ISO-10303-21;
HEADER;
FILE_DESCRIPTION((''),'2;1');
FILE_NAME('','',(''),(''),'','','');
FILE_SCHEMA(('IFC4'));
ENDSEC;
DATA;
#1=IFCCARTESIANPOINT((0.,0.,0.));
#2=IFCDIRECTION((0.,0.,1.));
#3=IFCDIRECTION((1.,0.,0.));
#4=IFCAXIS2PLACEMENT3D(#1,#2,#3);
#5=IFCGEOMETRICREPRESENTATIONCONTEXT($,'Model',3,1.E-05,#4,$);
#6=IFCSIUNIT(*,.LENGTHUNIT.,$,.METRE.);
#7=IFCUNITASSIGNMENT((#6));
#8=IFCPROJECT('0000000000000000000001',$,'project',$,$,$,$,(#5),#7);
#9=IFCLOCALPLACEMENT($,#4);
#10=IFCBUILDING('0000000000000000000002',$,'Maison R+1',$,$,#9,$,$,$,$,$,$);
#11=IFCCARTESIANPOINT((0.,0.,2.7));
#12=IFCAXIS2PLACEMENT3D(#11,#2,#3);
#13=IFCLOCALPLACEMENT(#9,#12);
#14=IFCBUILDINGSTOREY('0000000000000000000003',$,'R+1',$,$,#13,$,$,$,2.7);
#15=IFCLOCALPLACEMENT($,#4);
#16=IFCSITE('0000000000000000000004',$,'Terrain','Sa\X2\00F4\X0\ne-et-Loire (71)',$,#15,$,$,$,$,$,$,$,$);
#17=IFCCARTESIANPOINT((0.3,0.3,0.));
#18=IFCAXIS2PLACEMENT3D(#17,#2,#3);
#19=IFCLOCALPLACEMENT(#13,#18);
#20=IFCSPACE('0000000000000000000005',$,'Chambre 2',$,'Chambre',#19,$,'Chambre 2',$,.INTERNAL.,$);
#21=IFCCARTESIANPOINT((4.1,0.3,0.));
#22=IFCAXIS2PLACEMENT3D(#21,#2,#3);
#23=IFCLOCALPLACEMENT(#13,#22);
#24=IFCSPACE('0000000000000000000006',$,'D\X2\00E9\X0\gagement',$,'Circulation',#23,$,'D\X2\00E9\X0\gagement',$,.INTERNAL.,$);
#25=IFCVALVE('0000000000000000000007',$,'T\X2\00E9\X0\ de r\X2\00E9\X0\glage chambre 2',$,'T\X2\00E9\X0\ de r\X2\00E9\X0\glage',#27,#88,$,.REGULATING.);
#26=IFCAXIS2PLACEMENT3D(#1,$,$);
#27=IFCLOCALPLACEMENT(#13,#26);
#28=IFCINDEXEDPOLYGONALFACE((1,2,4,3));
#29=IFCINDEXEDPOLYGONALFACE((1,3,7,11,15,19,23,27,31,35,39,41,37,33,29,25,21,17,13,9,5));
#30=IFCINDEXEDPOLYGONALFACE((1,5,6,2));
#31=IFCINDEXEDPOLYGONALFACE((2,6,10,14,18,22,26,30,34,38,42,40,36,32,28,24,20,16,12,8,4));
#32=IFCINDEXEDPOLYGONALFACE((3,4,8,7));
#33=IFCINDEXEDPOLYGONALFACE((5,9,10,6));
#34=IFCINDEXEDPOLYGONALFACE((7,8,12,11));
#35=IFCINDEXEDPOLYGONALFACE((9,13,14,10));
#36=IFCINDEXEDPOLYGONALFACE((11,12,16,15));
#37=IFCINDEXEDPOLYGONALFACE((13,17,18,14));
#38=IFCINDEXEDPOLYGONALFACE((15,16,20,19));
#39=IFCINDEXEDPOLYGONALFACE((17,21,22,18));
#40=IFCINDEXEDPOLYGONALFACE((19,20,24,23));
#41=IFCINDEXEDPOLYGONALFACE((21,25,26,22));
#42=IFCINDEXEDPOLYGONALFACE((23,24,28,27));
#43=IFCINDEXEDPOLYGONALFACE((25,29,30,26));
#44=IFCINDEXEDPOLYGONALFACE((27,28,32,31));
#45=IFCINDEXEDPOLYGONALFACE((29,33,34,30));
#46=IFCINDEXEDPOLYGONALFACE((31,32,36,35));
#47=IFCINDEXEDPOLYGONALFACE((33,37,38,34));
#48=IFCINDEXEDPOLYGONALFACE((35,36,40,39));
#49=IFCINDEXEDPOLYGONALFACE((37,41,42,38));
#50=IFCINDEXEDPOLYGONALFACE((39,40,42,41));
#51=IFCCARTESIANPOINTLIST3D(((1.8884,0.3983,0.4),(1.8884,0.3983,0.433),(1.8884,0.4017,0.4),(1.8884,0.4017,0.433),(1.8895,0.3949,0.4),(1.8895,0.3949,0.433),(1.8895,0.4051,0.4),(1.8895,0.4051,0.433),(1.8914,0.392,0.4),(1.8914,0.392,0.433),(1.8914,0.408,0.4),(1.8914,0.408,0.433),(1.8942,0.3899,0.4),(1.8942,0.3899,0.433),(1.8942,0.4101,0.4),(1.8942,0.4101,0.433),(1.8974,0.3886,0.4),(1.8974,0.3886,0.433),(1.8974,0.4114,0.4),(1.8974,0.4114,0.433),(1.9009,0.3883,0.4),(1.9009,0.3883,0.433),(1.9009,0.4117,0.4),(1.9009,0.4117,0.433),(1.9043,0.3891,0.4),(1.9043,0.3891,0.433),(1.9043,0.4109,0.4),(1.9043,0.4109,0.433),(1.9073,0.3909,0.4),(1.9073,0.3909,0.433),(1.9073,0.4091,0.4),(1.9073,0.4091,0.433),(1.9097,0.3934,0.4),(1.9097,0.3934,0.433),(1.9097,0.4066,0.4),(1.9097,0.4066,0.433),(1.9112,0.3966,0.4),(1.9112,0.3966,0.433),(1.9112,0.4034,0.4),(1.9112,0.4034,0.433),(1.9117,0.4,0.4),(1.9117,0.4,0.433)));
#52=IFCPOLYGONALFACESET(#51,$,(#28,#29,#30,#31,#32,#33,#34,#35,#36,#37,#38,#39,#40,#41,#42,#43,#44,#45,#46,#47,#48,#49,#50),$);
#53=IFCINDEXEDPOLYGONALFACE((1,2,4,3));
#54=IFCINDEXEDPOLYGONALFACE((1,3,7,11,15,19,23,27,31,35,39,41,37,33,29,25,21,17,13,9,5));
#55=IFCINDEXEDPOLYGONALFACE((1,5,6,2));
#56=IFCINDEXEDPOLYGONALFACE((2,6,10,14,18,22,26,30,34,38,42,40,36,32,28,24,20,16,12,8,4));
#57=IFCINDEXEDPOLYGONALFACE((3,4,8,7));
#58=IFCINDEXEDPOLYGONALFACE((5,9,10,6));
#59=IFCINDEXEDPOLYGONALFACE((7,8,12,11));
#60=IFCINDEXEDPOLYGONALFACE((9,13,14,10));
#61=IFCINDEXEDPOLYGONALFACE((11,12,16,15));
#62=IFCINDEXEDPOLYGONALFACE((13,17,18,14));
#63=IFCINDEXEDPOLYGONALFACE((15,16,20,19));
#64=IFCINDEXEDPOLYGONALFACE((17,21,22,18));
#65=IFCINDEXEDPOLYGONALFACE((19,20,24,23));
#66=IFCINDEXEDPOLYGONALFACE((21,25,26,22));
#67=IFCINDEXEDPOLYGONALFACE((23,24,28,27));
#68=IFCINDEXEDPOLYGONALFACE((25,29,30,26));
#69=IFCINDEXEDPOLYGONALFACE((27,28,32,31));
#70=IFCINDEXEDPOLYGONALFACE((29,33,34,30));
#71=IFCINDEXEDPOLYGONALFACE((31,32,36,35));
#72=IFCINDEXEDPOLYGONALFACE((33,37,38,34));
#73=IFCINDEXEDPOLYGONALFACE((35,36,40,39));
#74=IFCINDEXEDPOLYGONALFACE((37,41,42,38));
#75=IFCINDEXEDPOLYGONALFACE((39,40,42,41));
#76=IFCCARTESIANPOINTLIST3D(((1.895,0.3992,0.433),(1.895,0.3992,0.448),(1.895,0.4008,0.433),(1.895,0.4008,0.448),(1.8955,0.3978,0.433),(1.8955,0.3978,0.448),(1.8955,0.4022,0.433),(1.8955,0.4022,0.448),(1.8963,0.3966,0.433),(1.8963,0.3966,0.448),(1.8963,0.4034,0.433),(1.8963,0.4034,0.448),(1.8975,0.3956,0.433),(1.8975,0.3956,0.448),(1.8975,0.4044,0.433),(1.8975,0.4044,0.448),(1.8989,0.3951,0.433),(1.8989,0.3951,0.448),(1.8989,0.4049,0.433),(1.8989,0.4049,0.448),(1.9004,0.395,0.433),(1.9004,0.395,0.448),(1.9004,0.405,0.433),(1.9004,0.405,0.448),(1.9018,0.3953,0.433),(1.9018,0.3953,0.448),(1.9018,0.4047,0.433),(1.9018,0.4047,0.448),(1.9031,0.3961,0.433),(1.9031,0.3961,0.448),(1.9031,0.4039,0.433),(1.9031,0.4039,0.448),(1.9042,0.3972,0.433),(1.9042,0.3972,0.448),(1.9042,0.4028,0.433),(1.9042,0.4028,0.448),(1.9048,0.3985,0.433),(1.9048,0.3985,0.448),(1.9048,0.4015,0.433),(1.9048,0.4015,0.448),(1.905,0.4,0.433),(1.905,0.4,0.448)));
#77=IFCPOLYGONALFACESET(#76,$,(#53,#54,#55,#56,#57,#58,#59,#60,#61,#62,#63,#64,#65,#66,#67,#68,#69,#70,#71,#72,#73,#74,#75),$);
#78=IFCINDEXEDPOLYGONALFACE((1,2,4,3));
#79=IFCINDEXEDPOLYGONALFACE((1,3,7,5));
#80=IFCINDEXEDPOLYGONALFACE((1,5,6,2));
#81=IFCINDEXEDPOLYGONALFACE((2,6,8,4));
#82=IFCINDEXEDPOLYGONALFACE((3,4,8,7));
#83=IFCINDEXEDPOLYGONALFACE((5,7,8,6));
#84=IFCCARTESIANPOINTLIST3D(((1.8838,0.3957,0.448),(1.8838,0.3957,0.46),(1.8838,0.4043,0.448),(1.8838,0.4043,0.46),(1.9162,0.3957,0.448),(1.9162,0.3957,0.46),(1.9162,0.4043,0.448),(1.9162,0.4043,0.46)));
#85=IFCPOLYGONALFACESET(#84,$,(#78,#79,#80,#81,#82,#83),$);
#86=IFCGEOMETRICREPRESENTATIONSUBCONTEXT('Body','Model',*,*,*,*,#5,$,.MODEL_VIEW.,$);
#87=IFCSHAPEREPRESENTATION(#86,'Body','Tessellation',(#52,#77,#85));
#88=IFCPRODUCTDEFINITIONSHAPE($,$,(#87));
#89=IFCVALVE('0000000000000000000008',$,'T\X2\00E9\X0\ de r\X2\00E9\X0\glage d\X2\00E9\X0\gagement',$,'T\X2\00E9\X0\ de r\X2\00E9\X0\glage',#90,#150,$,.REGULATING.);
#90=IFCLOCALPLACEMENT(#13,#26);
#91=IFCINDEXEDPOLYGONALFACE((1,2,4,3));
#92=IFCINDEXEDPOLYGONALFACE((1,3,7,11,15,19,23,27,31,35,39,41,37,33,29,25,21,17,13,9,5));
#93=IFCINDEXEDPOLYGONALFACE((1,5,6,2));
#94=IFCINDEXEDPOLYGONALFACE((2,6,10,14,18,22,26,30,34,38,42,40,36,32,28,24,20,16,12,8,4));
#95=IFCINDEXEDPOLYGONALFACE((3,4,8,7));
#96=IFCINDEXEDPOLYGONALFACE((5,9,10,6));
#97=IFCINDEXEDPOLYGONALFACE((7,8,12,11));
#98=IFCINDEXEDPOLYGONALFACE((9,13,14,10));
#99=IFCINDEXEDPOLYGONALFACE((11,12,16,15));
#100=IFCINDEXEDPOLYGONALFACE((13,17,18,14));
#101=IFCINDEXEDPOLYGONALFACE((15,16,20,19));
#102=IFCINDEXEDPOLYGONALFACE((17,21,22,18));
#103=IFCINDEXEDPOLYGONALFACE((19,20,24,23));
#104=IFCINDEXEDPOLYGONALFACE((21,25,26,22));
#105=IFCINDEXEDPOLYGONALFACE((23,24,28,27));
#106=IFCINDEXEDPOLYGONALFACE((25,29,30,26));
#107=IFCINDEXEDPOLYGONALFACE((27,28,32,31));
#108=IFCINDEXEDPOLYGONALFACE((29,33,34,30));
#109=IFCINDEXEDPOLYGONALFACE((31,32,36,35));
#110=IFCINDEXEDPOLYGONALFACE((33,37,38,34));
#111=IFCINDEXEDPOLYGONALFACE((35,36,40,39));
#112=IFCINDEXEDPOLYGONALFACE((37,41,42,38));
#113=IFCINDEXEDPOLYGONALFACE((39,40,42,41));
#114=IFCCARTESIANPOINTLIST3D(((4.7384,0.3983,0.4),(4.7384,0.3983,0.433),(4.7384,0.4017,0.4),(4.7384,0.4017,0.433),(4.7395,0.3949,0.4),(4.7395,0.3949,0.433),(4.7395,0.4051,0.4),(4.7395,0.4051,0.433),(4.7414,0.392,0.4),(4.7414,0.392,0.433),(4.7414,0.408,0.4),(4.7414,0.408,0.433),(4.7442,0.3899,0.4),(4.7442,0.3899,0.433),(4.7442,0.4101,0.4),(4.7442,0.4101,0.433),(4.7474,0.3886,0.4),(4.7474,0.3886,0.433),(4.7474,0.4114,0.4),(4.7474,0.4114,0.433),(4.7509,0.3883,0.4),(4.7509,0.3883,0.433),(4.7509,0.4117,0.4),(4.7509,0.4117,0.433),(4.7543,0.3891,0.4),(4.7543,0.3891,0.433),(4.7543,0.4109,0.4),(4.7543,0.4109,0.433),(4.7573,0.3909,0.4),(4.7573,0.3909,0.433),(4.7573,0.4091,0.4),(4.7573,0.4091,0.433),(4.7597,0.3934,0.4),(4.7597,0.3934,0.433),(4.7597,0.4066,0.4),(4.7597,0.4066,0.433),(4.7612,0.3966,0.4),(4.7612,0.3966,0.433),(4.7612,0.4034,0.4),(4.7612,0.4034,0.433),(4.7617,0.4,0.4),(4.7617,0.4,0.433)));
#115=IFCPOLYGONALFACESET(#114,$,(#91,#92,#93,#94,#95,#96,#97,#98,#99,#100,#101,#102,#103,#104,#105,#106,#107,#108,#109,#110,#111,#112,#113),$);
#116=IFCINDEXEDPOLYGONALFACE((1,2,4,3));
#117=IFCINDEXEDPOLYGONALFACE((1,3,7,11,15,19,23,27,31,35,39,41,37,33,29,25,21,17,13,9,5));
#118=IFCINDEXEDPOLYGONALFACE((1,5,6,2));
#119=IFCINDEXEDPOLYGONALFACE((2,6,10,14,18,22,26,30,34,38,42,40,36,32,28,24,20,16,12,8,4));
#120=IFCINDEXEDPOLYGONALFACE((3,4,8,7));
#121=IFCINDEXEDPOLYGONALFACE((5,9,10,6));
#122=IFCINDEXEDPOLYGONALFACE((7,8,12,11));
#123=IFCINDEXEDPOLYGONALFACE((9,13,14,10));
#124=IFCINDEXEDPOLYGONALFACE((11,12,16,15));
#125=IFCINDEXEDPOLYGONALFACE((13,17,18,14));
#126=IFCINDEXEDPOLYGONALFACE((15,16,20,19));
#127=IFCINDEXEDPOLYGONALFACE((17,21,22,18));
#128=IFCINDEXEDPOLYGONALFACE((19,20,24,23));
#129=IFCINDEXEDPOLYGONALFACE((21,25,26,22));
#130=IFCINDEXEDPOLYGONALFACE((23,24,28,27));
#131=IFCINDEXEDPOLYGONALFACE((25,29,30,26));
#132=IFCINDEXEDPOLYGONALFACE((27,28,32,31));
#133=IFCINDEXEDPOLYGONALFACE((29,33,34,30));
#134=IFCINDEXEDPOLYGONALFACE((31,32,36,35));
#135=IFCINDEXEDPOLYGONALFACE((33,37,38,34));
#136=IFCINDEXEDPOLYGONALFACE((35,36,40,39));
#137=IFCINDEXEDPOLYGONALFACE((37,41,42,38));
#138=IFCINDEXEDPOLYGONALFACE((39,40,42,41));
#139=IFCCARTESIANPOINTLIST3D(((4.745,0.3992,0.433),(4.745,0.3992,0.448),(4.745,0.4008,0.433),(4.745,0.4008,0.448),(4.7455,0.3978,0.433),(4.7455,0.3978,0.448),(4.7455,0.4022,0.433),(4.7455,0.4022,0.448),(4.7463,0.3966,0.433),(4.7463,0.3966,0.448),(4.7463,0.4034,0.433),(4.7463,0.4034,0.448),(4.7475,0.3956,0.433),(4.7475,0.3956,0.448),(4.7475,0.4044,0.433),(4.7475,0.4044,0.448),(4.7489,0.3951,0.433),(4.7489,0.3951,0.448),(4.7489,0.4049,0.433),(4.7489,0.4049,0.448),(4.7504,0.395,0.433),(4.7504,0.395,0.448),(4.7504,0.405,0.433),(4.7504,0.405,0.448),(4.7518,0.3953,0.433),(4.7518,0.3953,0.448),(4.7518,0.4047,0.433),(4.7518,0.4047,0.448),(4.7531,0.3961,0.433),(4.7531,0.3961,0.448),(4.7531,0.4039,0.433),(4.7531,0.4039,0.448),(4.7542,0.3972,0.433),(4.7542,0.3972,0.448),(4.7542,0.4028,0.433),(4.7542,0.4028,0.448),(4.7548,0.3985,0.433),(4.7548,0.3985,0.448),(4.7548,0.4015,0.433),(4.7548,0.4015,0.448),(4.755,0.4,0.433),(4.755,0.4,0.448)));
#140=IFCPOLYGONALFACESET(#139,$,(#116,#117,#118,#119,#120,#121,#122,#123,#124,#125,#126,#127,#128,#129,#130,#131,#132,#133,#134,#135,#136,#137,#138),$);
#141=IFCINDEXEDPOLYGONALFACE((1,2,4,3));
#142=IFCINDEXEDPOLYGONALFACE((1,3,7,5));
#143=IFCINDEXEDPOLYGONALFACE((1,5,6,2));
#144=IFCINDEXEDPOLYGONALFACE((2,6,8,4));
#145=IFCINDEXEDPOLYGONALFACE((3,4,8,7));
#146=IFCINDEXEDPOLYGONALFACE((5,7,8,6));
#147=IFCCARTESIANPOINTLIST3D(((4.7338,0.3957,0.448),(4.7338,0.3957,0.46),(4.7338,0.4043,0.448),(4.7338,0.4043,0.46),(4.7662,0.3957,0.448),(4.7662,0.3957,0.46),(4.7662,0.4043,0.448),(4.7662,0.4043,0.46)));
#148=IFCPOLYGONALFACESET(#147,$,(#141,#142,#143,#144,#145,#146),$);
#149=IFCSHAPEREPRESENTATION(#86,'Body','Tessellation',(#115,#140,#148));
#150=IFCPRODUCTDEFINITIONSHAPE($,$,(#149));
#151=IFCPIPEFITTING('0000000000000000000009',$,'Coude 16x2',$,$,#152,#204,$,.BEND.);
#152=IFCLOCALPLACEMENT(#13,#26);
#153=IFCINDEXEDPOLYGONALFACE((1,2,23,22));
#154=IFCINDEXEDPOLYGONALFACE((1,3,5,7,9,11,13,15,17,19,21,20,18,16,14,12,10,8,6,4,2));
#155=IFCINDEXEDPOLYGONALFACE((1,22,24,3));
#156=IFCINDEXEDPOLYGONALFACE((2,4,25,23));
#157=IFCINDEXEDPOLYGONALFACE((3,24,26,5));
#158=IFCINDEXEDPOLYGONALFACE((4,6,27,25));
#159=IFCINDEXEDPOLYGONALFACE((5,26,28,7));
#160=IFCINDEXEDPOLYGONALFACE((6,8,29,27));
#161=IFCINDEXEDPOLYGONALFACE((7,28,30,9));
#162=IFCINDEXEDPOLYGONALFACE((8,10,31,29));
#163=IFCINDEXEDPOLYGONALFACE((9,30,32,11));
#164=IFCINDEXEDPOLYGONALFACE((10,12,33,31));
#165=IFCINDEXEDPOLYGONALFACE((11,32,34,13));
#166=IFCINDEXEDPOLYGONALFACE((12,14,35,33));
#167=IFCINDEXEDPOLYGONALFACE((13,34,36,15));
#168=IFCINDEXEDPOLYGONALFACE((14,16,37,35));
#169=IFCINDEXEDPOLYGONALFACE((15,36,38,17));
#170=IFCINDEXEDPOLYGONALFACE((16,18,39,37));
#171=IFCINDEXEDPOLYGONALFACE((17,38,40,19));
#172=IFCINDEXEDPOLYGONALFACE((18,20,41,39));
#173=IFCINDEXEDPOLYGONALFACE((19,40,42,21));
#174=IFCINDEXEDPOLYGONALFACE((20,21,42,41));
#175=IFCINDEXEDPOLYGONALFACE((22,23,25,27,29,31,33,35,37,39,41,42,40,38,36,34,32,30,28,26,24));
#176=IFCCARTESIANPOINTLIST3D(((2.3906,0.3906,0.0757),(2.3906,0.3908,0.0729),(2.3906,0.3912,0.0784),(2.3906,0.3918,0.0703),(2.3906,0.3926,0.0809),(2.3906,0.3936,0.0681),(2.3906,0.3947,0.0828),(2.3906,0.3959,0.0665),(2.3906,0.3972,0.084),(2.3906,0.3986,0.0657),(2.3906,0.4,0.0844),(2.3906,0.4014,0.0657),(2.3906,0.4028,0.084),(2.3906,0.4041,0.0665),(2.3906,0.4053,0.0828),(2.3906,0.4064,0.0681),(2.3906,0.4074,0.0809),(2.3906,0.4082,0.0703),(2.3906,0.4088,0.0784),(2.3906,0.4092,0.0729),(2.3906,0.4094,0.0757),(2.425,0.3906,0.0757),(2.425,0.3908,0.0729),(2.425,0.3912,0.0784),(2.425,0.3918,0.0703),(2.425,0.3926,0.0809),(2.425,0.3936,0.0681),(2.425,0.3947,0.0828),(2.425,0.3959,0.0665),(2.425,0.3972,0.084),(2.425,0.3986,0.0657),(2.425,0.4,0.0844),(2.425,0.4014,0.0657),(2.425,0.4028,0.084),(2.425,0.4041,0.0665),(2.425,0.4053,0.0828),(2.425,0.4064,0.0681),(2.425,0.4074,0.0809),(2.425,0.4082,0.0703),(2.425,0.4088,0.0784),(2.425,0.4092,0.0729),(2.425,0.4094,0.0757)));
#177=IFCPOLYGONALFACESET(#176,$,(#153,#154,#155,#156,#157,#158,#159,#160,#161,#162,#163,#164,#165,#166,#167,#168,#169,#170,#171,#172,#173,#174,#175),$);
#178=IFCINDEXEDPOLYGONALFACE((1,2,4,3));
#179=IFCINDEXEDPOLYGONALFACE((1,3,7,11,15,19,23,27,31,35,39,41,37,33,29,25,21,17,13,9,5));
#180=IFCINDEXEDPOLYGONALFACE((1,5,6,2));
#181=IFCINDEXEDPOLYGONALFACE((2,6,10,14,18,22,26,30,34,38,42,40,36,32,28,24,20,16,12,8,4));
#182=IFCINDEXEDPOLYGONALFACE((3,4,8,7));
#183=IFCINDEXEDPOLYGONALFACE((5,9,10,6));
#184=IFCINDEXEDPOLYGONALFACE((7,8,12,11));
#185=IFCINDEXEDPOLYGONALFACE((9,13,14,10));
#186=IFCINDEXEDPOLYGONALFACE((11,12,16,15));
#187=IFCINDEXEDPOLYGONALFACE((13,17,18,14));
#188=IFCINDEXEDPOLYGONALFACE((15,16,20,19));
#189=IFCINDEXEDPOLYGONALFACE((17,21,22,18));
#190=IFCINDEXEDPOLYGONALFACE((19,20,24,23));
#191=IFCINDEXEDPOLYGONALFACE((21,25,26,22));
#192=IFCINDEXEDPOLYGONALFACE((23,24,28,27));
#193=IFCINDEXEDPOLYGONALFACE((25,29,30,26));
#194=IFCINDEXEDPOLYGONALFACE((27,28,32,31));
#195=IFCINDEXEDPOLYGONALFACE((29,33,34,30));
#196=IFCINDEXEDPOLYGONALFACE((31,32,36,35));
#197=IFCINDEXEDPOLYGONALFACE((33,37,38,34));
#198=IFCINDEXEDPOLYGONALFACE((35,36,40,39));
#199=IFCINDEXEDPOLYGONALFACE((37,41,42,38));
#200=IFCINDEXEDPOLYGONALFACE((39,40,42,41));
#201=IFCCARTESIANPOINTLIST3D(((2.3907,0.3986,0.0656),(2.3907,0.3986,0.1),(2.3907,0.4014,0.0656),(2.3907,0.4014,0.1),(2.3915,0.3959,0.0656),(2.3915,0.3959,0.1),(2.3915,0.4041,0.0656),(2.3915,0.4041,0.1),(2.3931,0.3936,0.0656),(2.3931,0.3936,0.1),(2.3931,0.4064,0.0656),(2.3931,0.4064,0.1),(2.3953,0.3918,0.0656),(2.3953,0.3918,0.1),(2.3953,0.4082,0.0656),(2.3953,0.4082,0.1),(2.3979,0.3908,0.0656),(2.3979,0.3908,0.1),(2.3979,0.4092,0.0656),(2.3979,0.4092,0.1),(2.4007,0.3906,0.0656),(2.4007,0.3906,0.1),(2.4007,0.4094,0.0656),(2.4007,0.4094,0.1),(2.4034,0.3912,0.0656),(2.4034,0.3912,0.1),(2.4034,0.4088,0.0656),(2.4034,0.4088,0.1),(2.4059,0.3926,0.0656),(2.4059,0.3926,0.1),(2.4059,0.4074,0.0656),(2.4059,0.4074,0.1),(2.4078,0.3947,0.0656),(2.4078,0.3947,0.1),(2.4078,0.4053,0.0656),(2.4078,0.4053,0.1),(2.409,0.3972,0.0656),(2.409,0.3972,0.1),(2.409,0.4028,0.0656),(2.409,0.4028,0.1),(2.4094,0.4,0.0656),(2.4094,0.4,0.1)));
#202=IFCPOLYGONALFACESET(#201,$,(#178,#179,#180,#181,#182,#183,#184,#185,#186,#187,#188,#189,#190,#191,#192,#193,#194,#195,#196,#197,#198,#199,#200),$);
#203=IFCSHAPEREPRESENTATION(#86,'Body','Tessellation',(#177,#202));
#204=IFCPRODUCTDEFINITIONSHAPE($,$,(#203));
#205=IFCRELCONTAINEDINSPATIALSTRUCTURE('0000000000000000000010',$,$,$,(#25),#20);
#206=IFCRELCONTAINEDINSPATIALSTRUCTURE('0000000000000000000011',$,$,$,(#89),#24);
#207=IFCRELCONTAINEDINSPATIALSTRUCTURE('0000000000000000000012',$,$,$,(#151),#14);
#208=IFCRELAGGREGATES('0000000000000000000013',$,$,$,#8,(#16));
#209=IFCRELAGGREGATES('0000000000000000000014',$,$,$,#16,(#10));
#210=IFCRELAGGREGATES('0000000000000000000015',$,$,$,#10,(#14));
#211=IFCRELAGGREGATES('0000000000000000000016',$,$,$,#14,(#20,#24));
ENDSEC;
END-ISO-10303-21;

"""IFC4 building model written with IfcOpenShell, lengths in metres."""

from ifc_helpers import new_model, si_unit, frame, frame_2d, origin_with_axes, place, context, subcontext, project, spatial, rectangle, circle, extrude, element, save


model = new_model("IFC4")

# Units and contexts
model_context = context("Model", 3, precision=1e-05, world=origin_with_axes())
body_context = subcontext(model_context, "Body", "Model", "MODEL_VIEW")
ifc_project = project(units=[si_unit("LENGTHUNIT", "METRE")], contexts=[model_context])

# Site, building, storey
site_placement = place(None, origin_with_axes())
site = spatial("IfcSite", under=ifc_project, at=site_placement, Name="Terrain", Description="Saône-et-Loire (71)")
building_placement = place(None, origin_with_axes())
building = spatial("IfcBuilding", under=site, at=building_placement, Name="Maison R+1")
storey_placement = place(building_placement, frame((0.0, 0.0, 2.7), z_axis=(0.0, 0.0, 1.0), x_axis=(1.0, 0.0, 0.0)))
storey = spatial("IfcBuildingStorey", under=building, at=storey_placement, Name="R+1", Elevation=2.7)

# Shared definitions
space_1_placement = place(storey_placement, frame((0.3, 0.3, 0.0), z_axis=(0.0, 0.0, 1.0), x_axis=(1.0, 0.0, 0.0)))
space_1 = spatial("IfcSpace", under=storey, at=space_1_placement, Name="Chambre 2", ObjectType="Chambre", LongName="Chambre 2", PredefinedType="INTERNAL")

# Valve
valve_1_placement = place(space_1_placement, frame((1.6, 0.1, 0.4), z_axis=(0.0, 0.0, 1.0), x_axis=(1.0, 0.0, 0.0)))
element("IfcValve", 1, at=valve_1_placement, inside=space_1, Name="Té de réglage chambre 2", ObjectType="Té de réglage", PredefinedType="REGULATING", context=body_context, shape_type="SweptSolid", body=[
    extrude(circle(Radius=0.0117), origin_with_axes(), (0.0, 0.0, 1.0), 0.033),
    extrude(circle(Radius=0.005), frame((0.0, 0.0, 0.033), z_axis=(0.0, 0.0, 1.0), x_axis=(1.0, 0.0, 0.0)), (0.0, 0.0, 1.0), 0.015),
    extrude(rectangle(XDim=0.0324, YDim=0.0086, at=frame_2d((0.0162, 0.0043))), frame((-0.0162, -0.0043, 0.048), z_axis=(0.0, 0.0, 1.0), x_axis=(1.0, 0.0, 0.0)), (0.0, 0.0, 1.0), 0.012),
])

# Shared definitions
space_2_placement = place(storey_placement, frame((4.1, 0.3, 0.0), z_axis=(0.0, 0.0, 1.0), x_axis=(1.0, 0.0, 0.0)))
space_2 = spatial("IfcSpace", under=storey, at=space_2_placement, Name="Dégagement", ObjectType="Circulation", LongName="Dégagement", PredefinedType="INTERNAL")

# Valve
valve_2_placement = place(space_2_placement, frame((0.65, 0.1, 0.4), z_axis=(0.0, 0.0, 1.0), x_axis=(1.0, 0.0, 0.0)))
element("IfcValve", 2, at=valve_2_placement, inside=space_2, Name="Té de réglage dégagement", ObjectType="Té de réglage", PredefinedType="REGULATING", context=body_context, shape_type="SweptSolid", body=[
    extrude(circle(Radius=0.0117), origin_with_axes(), (0.0, 0.0, 1.0), 0.033),
    extrude(circle(Radius=0.005), frame((0.0, 0.0, 0.033), z_axis=(0.0, 0.0, 1.0), x_axis=(1.0, 0.0, 0.0)), (0.0, 0.0, 1.0), 0.015),
    extrude(rectangle(XDim=0.0324, YDim=0.0086, at=frame_2d((0.0162, 0.0043))), frame((-0.0162, -0.0043, 0.048), z_axis=(0.0, 0.0, 1.0), x_axis=(1.0, 0.0, 0.0)), (0.0, 0.0, 1.0), 0.012),
])

# Pipe fitting
for number, where, z_axis, x_axis, name in (
    (3, (2.4, 0.4, 0.075), (0.0, 0.0, 1.0), (1.0, 0.0, 0.0), "Coude 16x2"),
):
    element("IfcPipeFitting", number, at=place(storey_placement, frame(where, z_axis=z_axis, x_axis=x_axis)), inside=storey, Name=name, PredefinedType="BEND", context=body_context, shape_type="SweptSolid", body=[
        extrude(circle(Radius=0.0094), frame((-0.0094, 0.0, 0.0), z_axis=(1.0, 0.0, 0.0), x_axis=(0.0, 0.0, 1.0)), (0.0, 0.0, 1.0), 0.0344),
        extrude(circle(Radius=0.0094), frame((0.0, 0.0, -0.0094), z_axis=(0.0, 0.0, 1.0), x_axis=(1.0, 0.0, 0.0)), (0.0, 0.0, 1.0), 0.0344),
    ])

save(model, "model.ifc")
